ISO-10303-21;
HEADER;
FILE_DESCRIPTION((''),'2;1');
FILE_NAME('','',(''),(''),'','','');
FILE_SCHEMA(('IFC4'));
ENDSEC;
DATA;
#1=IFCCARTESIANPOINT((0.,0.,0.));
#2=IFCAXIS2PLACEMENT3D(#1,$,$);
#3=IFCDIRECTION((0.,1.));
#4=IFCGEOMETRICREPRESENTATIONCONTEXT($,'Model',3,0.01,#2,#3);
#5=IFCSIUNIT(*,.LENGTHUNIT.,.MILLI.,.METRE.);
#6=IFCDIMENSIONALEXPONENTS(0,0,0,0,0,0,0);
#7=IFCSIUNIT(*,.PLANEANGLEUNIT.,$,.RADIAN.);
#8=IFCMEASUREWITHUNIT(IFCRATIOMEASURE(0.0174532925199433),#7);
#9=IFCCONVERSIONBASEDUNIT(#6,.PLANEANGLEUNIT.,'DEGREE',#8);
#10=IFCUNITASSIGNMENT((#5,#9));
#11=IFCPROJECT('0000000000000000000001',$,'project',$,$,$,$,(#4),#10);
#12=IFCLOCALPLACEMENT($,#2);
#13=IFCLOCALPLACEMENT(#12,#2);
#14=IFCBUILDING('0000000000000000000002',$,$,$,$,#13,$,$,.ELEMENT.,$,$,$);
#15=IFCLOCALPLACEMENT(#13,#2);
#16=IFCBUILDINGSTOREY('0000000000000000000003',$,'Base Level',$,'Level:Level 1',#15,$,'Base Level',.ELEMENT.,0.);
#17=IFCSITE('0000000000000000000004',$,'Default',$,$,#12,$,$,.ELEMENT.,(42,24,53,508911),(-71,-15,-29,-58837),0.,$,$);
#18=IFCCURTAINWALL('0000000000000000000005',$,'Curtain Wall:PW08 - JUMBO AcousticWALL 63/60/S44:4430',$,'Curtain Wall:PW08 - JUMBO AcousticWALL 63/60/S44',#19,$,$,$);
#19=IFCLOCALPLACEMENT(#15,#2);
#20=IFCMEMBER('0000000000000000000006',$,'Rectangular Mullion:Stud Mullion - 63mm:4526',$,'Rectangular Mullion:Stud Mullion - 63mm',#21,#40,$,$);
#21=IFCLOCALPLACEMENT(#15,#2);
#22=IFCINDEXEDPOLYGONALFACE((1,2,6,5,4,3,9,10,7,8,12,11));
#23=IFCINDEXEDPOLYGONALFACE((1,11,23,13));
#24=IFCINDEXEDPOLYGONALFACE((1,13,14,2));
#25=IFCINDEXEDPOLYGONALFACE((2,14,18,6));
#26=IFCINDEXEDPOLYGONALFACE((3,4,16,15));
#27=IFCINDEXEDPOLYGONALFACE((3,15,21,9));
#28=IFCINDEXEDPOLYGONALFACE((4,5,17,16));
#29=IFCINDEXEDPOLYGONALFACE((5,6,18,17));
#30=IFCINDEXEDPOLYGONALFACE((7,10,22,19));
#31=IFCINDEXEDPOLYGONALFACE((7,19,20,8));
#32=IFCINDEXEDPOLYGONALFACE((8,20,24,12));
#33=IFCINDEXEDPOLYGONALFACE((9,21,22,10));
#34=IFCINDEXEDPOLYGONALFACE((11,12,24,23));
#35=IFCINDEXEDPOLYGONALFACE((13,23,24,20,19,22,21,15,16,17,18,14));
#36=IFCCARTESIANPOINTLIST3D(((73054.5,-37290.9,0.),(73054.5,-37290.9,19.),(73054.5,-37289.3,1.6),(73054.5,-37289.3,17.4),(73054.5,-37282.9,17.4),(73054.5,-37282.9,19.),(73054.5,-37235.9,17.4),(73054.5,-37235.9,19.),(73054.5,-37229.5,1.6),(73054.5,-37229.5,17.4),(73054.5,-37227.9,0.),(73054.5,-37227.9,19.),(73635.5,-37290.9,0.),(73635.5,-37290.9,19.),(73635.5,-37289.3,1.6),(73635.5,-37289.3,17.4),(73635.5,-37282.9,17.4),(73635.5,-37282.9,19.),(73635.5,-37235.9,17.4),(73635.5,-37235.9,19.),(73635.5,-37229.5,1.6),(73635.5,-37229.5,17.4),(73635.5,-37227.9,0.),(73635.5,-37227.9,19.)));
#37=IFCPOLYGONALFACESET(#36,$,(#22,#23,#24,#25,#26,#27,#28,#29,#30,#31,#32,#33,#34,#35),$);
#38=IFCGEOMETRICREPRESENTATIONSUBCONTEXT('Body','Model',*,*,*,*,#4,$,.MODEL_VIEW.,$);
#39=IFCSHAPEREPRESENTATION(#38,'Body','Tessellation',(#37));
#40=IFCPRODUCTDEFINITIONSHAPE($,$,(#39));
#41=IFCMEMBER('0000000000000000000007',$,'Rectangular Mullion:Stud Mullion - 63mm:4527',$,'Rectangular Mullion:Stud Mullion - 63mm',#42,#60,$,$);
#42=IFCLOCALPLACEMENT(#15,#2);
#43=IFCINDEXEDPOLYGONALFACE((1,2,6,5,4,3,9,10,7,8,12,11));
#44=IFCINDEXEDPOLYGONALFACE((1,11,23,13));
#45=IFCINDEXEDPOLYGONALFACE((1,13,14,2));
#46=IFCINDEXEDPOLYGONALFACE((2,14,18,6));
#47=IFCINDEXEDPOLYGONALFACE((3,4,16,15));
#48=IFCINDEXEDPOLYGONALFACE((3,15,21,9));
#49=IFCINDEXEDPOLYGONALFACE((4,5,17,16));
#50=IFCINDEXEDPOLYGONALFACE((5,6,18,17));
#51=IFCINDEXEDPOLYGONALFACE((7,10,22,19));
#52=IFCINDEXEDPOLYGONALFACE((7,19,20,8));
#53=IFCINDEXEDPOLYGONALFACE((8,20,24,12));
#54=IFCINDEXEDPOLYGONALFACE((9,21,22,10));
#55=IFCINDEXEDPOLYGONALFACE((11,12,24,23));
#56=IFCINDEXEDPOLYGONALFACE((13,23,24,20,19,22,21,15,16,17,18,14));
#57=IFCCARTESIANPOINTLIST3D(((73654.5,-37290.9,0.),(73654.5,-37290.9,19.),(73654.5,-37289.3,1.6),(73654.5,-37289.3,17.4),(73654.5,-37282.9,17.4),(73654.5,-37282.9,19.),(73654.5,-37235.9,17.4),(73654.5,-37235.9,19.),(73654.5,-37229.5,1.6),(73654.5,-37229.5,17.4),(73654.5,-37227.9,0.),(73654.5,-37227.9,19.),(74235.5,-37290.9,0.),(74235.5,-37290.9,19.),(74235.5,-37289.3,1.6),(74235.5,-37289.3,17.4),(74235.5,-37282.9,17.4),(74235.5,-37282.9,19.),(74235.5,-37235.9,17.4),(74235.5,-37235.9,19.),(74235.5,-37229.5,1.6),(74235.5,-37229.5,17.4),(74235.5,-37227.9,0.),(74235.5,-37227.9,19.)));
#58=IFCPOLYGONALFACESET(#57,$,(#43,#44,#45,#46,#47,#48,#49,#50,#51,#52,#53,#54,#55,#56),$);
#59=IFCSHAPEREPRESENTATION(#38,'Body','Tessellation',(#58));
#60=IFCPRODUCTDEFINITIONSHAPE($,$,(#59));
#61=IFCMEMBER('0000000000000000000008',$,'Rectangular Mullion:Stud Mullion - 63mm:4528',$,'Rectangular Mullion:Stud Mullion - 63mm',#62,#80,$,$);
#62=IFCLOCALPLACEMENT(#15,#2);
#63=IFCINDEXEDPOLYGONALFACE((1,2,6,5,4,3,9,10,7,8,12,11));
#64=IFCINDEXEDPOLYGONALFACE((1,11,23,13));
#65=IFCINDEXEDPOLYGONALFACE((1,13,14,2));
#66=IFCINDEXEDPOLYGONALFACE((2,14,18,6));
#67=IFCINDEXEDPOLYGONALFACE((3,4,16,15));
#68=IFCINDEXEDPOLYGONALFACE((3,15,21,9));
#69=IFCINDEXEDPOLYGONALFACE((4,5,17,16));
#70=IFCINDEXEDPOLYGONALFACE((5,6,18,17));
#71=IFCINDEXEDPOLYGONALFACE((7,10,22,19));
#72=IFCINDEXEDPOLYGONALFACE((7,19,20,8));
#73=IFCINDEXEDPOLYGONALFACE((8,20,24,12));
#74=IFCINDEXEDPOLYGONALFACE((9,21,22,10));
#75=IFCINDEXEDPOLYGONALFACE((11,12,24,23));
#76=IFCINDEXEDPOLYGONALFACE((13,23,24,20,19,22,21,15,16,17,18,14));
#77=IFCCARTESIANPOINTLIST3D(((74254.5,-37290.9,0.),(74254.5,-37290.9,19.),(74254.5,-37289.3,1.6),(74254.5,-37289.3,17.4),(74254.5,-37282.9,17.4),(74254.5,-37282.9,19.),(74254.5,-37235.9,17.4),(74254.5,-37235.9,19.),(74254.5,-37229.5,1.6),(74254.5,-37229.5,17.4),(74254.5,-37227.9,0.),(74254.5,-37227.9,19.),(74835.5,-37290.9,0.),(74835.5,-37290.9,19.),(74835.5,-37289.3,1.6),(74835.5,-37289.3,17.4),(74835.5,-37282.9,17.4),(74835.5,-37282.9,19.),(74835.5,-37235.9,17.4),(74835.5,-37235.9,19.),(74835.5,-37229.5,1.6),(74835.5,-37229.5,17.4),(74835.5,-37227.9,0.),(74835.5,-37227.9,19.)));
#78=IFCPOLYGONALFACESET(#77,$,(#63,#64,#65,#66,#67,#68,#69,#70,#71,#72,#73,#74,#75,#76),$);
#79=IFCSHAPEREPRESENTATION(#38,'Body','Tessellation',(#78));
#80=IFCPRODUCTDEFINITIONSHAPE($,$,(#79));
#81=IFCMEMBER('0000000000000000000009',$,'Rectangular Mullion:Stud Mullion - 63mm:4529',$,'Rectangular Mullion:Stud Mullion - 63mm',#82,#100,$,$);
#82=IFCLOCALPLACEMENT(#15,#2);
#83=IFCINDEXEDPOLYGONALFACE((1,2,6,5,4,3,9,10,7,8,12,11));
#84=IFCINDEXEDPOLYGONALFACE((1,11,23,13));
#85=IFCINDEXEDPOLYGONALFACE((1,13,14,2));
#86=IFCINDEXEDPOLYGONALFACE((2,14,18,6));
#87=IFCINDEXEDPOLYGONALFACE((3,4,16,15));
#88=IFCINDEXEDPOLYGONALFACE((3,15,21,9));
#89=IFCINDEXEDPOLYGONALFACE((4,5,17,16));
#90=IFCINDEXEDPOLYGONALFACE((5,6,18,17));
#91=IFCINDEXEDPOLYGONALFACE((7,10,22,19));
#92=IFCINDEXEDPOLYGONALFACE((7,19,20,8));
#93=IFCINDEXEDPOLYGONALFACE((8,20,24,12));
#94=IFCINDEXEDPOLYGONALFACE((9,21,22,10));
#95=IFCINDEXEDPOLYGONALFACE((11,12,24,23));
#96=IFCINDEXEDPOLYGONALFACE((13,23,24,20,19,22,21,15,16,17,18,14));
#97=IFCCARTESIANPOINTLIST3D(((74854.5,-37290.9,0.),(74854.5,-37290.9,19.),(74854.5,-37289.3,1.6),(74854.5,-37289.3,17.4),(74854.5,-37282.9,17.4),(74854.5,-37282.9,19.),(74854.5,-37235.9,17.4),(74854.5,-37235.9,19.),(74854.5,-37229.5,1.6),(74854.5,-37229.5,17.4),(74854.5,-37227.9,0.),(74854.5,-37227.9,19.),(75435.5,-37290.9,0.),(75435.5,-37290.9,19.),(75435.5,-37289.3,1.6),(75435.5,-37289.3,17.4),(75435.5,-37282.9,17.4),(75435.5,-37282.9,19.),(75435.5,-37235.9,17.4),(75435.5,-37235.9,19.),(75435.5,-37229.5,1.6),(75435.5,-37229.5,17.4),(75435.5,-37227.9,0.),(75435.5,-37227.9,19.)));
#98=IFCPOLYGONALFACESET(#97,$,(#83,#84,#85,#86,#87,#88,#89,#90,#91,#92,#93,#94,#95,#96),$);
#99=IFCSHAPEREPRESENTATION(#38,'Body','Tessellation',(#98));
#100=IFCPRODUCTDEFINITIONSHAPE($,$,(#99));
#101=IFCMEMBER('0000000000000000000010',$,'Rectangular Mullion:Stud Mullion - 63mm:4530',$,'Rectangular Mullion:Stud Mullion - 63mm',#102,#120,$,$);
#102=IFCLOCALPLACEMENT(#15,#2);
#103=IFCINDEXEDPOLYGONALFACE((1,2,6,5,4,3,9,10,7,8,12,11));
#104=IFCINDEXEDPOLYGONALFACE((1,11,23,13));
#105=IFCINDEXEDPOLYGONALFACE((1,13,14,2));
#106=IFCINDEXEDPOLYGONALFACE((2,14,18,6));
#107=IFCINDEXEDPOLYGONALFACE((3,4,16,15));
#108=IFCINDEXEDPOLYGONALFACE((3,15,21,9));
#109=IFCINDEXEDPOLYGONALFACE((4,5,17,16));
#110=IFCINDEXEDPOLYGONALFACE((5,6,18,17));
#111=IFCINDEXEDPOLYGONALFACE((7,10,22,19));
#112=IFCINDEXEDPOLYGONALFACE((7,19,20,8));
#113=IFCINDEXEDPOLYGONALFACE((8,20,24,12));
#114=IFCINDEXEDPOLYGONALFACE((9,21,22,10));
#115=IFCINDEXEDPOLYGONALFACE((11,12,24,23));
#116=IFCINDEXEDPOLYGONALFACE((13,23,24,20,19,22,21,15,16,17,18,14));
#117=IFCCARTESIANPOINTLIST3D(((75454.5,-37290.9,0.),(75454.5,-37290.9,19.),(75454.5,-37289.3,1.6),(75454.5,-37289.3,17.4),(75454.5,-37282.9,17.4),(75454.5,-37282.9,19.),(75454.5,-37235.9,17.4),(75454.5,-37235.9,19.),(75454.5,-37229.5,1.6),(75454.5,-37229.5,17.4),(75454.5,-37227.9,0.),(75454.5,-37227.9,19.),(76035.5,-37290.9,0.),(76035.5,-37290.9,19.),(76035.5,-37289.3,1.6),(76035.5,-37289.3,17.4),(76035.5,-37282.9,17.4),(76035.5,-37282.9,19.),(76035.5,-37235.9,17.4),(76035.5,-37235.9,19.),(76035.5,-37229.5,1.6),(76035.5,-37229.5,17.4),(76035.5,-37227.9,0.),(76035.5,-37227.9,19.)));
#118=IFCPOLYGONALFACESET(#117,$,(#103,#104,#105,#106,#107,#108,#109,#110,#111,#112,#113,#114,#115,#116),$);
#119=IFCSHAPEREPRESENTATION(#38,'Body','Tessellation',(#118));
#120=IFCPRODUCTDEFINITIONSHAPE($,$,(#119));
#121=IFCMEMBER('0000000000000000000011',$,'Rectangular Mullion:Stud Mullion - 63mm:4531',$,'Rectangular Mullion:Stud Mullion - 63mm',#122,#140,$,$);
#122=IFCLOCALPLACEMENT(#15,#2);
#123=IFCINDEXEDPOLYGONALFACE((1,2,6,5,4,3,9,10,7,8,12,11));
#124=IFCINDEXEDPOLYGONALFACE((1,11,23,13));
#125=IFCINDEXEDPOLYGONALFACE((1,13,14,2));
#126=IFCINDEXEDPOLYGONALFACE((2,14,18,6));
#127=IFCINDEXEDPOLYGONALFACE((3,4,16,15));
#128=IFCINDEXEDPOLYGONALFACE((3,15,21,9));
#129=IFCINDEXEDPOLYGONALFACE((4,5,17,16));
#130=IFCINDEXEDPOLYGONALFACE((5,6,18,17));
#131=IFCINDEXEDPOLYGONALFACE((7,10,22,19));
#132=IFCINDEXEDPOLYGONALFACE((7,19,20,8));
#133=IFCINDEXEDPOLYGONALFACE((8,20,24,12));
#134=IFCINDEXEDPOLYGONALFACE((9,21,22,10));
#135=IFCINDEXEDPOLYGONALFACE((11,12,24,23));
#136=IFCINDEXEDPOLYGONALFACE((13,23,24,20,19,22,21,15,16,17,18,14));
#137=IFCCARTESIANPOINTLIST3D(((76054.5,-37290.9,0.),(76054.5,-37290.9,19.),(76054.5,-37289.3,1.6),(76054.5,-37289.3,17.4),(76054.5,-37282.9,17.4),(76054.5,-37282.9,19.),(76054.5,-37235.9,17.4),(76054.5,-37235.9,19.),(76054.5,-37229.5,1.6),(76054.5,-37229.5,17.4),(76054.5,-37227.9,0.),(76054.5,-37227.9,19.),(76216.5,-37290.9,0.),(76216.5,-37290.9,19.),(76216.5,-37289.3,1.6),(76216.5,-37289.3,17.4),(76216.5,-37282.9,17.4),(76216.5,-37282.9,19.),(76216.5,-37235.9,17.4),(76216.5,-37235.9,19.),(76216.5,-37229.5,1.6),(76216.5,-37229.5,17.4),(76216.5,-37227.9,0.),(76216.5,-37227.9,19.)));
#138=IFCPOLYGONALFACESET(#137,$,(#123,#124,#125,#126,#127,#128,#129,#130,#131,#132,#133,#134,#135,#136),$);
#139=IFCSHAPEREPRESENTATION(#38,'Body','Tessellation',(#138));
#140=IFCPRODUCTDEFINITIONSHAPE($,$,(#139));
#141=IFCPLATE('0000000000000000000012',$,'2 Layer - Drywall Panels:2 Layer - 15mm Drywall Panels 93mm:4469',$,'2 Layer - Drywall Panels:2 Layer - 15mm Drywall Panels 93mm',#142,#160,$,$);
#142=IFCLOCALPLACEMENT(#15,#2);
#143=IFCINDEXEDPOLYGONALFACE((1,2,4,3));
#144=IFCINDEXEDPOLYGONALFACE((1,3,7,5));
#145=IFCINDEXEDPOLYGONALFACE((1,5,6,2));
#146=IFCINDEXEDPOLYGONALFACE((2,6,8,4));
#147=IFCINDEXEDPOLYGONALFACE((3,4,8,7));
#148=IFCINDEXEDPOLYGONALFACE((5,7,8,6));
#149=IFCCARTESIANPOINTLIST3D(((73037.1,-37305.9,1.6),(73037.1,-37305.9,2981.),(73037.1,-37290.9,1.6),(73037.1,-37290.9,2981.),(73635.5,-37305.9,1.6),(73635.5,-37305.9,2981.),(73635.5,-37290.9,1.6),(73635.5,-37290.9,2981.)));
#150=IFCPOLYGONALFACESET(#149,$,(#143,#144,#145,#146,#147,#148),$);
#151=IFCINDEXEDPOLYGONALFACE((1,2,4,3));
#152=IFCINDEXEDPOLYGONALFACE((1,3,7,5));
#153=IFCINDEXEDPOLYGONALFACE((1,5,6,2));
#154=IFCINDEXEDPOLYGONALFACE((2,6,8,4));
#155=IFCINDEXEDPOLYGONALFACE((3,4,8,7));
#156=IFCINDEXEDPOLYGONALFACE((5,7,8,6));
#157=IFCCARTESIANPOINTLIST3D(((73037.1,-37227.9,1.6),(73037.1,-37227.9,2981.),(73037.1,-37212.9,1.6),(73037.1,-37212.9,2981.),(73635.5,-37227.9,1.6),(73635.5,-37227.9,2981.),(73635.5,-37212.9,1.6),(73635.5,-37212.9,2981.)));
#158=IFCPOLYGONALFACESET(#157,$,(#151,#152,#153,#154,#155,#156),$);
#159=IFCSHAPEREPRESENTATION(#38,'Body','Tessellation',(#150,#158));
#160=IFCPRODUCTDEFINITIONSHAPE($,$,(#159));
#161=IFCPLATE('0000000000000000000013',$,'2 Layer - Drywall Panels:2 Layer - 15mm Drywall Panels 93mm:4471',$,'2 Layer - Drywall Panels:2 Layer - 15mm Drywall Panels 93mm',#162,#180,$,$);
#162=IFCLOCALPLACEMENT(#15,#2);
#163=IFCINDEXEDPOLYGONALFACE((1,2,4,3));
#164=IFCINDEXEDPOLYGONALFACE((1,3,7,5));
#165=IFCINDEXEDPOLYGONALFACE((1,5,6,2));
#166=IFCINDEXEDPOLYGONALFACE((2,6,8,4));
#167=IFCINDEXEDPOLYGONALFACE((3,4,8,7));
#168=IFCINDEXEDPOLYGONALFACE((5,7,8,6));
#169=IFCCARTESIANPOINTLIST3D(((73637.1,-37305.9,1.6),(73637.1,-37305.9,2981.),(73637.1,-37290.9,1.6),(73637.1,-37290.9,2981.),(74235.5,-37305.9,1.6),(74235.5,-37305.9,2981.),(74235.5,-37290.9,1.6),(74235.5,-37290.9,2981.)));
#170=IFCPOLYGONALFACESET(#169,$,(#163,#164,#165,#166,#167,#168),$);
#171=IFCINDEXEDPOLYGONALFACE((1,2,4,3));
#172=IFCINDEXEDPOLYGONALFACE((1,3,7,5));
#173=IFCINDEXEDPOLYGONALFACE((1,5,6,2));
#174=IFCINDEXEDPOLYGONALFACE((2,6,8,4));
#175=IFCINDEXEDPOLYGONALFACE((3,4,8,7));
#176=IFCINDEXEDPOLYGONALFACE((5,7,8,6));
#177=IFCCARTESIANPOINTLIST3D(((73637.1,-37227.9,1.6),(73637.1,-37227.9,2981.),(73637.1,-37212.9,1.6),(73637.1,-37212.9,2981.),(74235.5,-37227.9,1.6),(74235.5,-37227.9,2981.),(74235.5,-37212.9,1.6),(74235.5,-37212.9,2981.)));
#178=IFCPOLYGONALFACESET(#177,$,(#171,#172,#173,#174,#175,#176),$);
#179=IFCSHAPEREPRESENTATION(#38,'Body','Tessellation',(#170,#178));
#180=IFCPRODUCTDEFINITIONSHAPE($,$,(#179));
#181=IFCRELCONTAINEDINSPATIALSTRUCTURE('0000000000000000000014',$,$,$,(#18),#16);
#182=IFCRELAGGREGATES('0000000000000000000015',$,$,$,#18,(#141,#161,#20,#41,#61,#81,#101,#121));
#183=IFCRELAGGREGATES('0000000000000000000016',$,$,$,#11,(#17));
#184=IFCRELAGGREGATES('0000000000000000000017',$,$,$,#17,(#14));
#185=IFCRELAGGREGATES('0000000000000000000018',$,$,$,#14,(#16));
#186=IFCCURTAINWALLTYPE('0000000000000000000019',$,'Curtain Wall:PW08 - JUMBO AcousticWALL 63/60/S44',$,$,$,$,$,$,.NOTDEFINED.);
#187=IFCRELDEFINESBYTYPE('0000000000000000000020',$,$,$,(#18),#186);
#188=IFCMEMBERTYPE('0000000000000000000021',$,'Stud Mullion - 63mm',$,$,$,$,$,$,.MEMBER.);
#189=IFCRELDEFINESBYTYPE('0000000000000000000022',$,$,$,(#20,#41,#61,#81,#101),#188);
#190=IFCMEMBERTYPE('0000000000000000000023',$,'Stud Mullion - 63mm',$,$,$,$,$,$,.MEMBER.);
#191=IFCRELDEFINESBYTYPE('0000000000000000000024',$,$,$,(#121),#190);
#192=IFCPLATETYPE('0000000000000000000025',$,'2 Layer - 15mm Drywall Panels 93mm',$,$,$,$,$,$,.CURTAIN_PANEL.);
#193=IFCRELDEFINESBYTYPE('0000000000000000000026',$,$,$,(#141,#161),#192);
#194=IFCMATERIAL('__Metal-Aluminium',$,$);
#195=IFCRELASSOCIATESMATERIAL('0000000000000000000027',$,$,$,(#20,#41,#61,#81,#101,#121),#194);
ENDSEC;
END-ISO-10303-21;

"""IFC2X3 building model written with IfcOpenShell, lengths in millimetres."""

from ifc_helpers import new_model, entity, si_unit, converted_unit, direction, frame, frame_2d, origin, place, context, subcontext, project, spatial, polyline, rectangle, outline, extrude, source, transform, mapped, material, type_object, type_shapes, element, aggregate, save


model = new_model("IFC2X3")

# Units and contexts
model_context = context("Model", 3, precision=0.01, world=origin(), true_north=direction((0.0, 1.0)))
body_context = subcontext(model_context, "Body", "Model", "MODEL_VIEW")
ifc_project = project(units=[si_unit("LENGTHUNIT", "METRE", prefix="MILLI"), converted_unit("PLANEANGLEUNIT", "DEGREE", entity("IfcRatioMeasure", 0.0174532925199433), si_unit("PLANEANGLEUNIT", "RADIAN"), dimensions=[0, 0, 0, 0, 0, 0, 0])], contexts=[model_context])

# Site, building, storey
site_placement = place(None, origin())
site = spatial("IfcSite", under=ifc_project, at=site_placement, Name="Default", CompositionType="ELEMENT", RefLatitude=(42, 24, 53, 508911), RefLongitude=(-71, -15, -29, -58837), RefElevation=0.0)
building_placement = place(site_placement, origin())
building = spatial("IfcBuilding", under=site, at=building_placement, CompositionType="ELEMENT")
storey_placement = place(building_placement, origin())
storey = spatial("IfcBuildingStorey", under=building, at=storey_placement, Name="Base Level", ObjectType="Level:Level 1", LongName="Base Level", CompositionType="ELEMENT", Elevation=0.0)

# Curtain wall, members, plates
curtain_wall_type = type_object("IfcCurtainWallType", Name="Curtain Wall:PW08 - JUMBO AcousticWALL 63/60/S44", PredefinedType="NOTDEFINED")
curtain_wall_placement = place(building_placement, origin())
curtain_wall = element("IfcCurtainWall", 1, at=curtain_wall_placement, inside=storey, type_object=curtain_wall_type, Name="Curtain Wall:PW08 - JUMBO AcousticWALL 63/60/S44:4430", ObjectType="Curtain Wall:PW08 - JUMBO AcousticWALL 63/60/S44")
ifc_material = material(Name="__Metal-Aluminium")
member_type_1 = type_object("IfcMemberType", Name="Stud Mullion - 63mm", PredefinedType="MEMBER")
shared_shape_1 = source(origin(), body_context, "Body", "SweptSolid", [
    extrude(outline(polyline([(23.5, -6.6), (31.5, -6.6), (31.5, 12.4), (-31.5, 12.4), (-31.5, -6.6), (-23.5, -6.6), (-23.5, -5.0), (-29.9, -5.0), (-29.9, 10.8), (29.9, 10.8), (29.9, -5.0), (23.5, -5.0), (23.5, -6.6)])), frame((-12.4, 0.0, -581.0), z_axis=(0.0, 0.0, 1.0), x_axis=(0.0, -1.0, 0.0)), (0.0, 0.0, 1.0), 581.0),
])
type_shapes(member_type_1, [shared_shape_1])
member_1_placement = place(building_placement, frame((73054.5, -37259.4, 0.0), z_axis=(-1.0, 0.0, 0.0), x_axis=(0.0, 0.0, -1.0)))
member_1 = element("IfcMember", 2, at=member_1_placement, type_object=member_type_1, material=ifc_material, Name="Rectangular Mullion:Stud Mullion - 63mm:4526", ObjectType="Rectangular Mullion:Stud Mullion - 63mm", context=body_context, shape_type="MappedRepresentation", body=[
    mapped(shared_shape_1, transform((0.0, 0.0, 0.0), scale=1.0)),
])
member_2_placement = place(building_placement, frame((73654.5, -37259.4, 0.0), z_axis=(-1.0, 0.0, 0.0), x_axis=(0.0, 0.0, -1.0)))
member_2 = element("IfcMember", 3, at=member_2_placement, type_object=member_type_1, material=ifc_material, Name="Rectangular Mullion:Stud Mullion - 63mm:4527", ObjectType="Rectangular Mullion:Stud Mullion - 63mm", context=body_context, shape_type="MappedRepresentation", body=[
    mapped(shared_shape_1, transform((0.0, 0.0, 0.0), scale=1.0)),
])
member_3_placement = place(building_placement, frame((74254.5, -37259.4, 0.0), z_axis=(-1.0, 0.0, 0.0), x_axis=(0.0, 0.0, -1.0)))
member_3 = element("IfcMember", 4, at=member_3_placement, type_object=member_type_1, material=ifc_material, Name="Rectangular Mullion:Stud Mullion - 63mm:4528", ObjectType="Rectangular Mullion:Stud Mullion - 63mm", context=body_context, shape_type="MappedRepresentation", body=[
    mapped(shared_shape_1, transform((0.0, 0.0, 0.0), scale=1.0)),
])
member_4_placement = place(building_placement, frame((74854.5, -37259.4, 0.0), z_axis=(-1.0, 0.0, 0.0), x_axis=(0.0, 0.0, -1.0)))
member_4 = element("IfcMember", 5, at=member_4_placement, type_object=member_type_1, material=ifc_material, Name="Rectangular Mullion:Stud Mullion - 63mm:4529", ObjectType="Rectangular Mullion:Stud Mullion - 63mm", context=body_context, shape_type="MappedRepresentation", body=[
    mapped(shared_shape_1, transform((0.0, 0.0, 0.0), scale=1.0)),
])
member_5_placement = place(building_placement, frame((75454.5, -37259.4, 0.0), z_axis=(-1.0, 0.0, 0.0), x_axis=(0.0, 0.0, -1.0)))
member_5 = element("IfcMember", 6, at=member_5_placement, type_object=member_type_1, material=ifc_material, Name="Rectangular Mullion:Stud Mullion - 63mm:4530", ObjectType="Rectangular Mullion:Stud Mullion - 63mm", context=body_context, shape_type="MappedRepresentation", body=[
    mapped(shared_shape_1, transform((0.0, 0.0, 0.0), scale=1.0)),
])
member_type_2 = type_object("IfcMemberType", Name="Stud Mullion - 63mm", PredefinedType="MEMBER")
shared_shape_2 = source(origin(), body_context, "Body", "SweptSolid", [
    extrude(outline(polyline([(23.5, -6.6), (31.5, -6.6), (31.5, 12.4), (-31.5, 12.4), (-31.5, -6.6), (-23.5, -6.6), (-23.5, -5.0), (-29.9, -5.0), (-29.9, 10.8), (29.9, 10.8), (29.9, -5.0), (23.5, -5.0), (23.5, -6.6)])), frame((-12.4, 0.0, -162.0), z_axis=(0.0, 0.0, 1.0), x_axis=(0.0, -1.0, 0.0)), (0.0, 0.0, 1.0), 162.0),
])
type_shapes(member_type_2, [shared_shape_2])
member_6_placement = place(building_placement, frame((76054.5, -37259.4, 0.0), z_axis=(-1.0, 0.0, 0.0), x_axis=(0.0, 0.0, -1.0)))
member_6 = element("IfcMember", 7, at=member_6_placement, type_object=member_type_2, material=ifc_material, Name="Rectangular Mullion:Stud Mullion - 63mm:4531", ObjectType="Rectangular Mullion:Stud Mullion - 63mm", context=body_context, shape_type="MappedRepresentation", body=[
    mapped(shared_shape_2, transform((0.0, 0.0, 0.0), scale=1.0)),
])
plate_type_1 = type_object("IfcPlateType", Name="2 Layer - 15mm Drywall Panels 93mm", PredefinedType="CURTAIN_PANEL")
shared_shape_3 = source(origin(), body_context, "Body", "SweptSolid", [
    extrude(rectangle(XDim=598.4, YDim=15.0, at=frame_2d((0.0, 0.0), x_axis=(1.0, 0.0))), frame((0.0, -39.0, 0.0), z_axis=(0.0, 0.0, 1.0), x_axis=(-1.0, 0.0, 0.0)), (0.0, 0.0, 1.0), 2979.4),
    extrude(rectangle(XDim=15.0, YDim=598.4, at=frame_2d((0.0, 0.0), x_axis=(1.0, 0.0))), frame((0.0, 39.0, 0.0), z_axis=(0.0, 0.0, 1.0), x_axis=(0.0, 1.0, 0.0)), (0.0, 0.0, 1.0), 2979.4),
])
type_shapes(plate_type_1, [shared_shape_3])
plate_1_placement = place(curtain_wall_placement, frame((73336.3, -37259.4, 1.6)))
plate_1 = element("IfcPlate", 8, at=plate_1_placement, type_object=plate_type_1, Name="2 Layer - Drywall Panels:2 Layer - 15mm Drywall Panels 93mm:4469", ObjectType="2 Layer - Drywall Panels:2 Layer - 15mm Drywall Panels 93mm", context=body_context, shape_type="MappedRepresentation", body=[
    mapped(shared_shape_3, transform((0.0, 0.0, 0.0), scale=1.0)),
])
plate_2_placement = place(curtain_wall_placement, frame((73936.3, -37259.4, 1.6)))
plate_2 = element("IfcPlate", 9, at=plate_2_placement, type_object=plate_type_1, Name="2 Layer - Drywall Panels:2 Layer - 15mm Drywall Panels 93mm:4471", ObjectType="2 Layer - Drywall Panels:2 Layer - 15mm Drywall Panels 93mm", context=body_context, shape_type="MappedRepresentation", body=[
    mapped(shared_shape_3, transform((0.0, 0.0, 0.0), scale=1.0)),
])
aggregate(curtain_wall, [plate_1, plate_2, member_1, member_2, member_3, member_4, member_5, member_6])

save(model, "model.ifc")
